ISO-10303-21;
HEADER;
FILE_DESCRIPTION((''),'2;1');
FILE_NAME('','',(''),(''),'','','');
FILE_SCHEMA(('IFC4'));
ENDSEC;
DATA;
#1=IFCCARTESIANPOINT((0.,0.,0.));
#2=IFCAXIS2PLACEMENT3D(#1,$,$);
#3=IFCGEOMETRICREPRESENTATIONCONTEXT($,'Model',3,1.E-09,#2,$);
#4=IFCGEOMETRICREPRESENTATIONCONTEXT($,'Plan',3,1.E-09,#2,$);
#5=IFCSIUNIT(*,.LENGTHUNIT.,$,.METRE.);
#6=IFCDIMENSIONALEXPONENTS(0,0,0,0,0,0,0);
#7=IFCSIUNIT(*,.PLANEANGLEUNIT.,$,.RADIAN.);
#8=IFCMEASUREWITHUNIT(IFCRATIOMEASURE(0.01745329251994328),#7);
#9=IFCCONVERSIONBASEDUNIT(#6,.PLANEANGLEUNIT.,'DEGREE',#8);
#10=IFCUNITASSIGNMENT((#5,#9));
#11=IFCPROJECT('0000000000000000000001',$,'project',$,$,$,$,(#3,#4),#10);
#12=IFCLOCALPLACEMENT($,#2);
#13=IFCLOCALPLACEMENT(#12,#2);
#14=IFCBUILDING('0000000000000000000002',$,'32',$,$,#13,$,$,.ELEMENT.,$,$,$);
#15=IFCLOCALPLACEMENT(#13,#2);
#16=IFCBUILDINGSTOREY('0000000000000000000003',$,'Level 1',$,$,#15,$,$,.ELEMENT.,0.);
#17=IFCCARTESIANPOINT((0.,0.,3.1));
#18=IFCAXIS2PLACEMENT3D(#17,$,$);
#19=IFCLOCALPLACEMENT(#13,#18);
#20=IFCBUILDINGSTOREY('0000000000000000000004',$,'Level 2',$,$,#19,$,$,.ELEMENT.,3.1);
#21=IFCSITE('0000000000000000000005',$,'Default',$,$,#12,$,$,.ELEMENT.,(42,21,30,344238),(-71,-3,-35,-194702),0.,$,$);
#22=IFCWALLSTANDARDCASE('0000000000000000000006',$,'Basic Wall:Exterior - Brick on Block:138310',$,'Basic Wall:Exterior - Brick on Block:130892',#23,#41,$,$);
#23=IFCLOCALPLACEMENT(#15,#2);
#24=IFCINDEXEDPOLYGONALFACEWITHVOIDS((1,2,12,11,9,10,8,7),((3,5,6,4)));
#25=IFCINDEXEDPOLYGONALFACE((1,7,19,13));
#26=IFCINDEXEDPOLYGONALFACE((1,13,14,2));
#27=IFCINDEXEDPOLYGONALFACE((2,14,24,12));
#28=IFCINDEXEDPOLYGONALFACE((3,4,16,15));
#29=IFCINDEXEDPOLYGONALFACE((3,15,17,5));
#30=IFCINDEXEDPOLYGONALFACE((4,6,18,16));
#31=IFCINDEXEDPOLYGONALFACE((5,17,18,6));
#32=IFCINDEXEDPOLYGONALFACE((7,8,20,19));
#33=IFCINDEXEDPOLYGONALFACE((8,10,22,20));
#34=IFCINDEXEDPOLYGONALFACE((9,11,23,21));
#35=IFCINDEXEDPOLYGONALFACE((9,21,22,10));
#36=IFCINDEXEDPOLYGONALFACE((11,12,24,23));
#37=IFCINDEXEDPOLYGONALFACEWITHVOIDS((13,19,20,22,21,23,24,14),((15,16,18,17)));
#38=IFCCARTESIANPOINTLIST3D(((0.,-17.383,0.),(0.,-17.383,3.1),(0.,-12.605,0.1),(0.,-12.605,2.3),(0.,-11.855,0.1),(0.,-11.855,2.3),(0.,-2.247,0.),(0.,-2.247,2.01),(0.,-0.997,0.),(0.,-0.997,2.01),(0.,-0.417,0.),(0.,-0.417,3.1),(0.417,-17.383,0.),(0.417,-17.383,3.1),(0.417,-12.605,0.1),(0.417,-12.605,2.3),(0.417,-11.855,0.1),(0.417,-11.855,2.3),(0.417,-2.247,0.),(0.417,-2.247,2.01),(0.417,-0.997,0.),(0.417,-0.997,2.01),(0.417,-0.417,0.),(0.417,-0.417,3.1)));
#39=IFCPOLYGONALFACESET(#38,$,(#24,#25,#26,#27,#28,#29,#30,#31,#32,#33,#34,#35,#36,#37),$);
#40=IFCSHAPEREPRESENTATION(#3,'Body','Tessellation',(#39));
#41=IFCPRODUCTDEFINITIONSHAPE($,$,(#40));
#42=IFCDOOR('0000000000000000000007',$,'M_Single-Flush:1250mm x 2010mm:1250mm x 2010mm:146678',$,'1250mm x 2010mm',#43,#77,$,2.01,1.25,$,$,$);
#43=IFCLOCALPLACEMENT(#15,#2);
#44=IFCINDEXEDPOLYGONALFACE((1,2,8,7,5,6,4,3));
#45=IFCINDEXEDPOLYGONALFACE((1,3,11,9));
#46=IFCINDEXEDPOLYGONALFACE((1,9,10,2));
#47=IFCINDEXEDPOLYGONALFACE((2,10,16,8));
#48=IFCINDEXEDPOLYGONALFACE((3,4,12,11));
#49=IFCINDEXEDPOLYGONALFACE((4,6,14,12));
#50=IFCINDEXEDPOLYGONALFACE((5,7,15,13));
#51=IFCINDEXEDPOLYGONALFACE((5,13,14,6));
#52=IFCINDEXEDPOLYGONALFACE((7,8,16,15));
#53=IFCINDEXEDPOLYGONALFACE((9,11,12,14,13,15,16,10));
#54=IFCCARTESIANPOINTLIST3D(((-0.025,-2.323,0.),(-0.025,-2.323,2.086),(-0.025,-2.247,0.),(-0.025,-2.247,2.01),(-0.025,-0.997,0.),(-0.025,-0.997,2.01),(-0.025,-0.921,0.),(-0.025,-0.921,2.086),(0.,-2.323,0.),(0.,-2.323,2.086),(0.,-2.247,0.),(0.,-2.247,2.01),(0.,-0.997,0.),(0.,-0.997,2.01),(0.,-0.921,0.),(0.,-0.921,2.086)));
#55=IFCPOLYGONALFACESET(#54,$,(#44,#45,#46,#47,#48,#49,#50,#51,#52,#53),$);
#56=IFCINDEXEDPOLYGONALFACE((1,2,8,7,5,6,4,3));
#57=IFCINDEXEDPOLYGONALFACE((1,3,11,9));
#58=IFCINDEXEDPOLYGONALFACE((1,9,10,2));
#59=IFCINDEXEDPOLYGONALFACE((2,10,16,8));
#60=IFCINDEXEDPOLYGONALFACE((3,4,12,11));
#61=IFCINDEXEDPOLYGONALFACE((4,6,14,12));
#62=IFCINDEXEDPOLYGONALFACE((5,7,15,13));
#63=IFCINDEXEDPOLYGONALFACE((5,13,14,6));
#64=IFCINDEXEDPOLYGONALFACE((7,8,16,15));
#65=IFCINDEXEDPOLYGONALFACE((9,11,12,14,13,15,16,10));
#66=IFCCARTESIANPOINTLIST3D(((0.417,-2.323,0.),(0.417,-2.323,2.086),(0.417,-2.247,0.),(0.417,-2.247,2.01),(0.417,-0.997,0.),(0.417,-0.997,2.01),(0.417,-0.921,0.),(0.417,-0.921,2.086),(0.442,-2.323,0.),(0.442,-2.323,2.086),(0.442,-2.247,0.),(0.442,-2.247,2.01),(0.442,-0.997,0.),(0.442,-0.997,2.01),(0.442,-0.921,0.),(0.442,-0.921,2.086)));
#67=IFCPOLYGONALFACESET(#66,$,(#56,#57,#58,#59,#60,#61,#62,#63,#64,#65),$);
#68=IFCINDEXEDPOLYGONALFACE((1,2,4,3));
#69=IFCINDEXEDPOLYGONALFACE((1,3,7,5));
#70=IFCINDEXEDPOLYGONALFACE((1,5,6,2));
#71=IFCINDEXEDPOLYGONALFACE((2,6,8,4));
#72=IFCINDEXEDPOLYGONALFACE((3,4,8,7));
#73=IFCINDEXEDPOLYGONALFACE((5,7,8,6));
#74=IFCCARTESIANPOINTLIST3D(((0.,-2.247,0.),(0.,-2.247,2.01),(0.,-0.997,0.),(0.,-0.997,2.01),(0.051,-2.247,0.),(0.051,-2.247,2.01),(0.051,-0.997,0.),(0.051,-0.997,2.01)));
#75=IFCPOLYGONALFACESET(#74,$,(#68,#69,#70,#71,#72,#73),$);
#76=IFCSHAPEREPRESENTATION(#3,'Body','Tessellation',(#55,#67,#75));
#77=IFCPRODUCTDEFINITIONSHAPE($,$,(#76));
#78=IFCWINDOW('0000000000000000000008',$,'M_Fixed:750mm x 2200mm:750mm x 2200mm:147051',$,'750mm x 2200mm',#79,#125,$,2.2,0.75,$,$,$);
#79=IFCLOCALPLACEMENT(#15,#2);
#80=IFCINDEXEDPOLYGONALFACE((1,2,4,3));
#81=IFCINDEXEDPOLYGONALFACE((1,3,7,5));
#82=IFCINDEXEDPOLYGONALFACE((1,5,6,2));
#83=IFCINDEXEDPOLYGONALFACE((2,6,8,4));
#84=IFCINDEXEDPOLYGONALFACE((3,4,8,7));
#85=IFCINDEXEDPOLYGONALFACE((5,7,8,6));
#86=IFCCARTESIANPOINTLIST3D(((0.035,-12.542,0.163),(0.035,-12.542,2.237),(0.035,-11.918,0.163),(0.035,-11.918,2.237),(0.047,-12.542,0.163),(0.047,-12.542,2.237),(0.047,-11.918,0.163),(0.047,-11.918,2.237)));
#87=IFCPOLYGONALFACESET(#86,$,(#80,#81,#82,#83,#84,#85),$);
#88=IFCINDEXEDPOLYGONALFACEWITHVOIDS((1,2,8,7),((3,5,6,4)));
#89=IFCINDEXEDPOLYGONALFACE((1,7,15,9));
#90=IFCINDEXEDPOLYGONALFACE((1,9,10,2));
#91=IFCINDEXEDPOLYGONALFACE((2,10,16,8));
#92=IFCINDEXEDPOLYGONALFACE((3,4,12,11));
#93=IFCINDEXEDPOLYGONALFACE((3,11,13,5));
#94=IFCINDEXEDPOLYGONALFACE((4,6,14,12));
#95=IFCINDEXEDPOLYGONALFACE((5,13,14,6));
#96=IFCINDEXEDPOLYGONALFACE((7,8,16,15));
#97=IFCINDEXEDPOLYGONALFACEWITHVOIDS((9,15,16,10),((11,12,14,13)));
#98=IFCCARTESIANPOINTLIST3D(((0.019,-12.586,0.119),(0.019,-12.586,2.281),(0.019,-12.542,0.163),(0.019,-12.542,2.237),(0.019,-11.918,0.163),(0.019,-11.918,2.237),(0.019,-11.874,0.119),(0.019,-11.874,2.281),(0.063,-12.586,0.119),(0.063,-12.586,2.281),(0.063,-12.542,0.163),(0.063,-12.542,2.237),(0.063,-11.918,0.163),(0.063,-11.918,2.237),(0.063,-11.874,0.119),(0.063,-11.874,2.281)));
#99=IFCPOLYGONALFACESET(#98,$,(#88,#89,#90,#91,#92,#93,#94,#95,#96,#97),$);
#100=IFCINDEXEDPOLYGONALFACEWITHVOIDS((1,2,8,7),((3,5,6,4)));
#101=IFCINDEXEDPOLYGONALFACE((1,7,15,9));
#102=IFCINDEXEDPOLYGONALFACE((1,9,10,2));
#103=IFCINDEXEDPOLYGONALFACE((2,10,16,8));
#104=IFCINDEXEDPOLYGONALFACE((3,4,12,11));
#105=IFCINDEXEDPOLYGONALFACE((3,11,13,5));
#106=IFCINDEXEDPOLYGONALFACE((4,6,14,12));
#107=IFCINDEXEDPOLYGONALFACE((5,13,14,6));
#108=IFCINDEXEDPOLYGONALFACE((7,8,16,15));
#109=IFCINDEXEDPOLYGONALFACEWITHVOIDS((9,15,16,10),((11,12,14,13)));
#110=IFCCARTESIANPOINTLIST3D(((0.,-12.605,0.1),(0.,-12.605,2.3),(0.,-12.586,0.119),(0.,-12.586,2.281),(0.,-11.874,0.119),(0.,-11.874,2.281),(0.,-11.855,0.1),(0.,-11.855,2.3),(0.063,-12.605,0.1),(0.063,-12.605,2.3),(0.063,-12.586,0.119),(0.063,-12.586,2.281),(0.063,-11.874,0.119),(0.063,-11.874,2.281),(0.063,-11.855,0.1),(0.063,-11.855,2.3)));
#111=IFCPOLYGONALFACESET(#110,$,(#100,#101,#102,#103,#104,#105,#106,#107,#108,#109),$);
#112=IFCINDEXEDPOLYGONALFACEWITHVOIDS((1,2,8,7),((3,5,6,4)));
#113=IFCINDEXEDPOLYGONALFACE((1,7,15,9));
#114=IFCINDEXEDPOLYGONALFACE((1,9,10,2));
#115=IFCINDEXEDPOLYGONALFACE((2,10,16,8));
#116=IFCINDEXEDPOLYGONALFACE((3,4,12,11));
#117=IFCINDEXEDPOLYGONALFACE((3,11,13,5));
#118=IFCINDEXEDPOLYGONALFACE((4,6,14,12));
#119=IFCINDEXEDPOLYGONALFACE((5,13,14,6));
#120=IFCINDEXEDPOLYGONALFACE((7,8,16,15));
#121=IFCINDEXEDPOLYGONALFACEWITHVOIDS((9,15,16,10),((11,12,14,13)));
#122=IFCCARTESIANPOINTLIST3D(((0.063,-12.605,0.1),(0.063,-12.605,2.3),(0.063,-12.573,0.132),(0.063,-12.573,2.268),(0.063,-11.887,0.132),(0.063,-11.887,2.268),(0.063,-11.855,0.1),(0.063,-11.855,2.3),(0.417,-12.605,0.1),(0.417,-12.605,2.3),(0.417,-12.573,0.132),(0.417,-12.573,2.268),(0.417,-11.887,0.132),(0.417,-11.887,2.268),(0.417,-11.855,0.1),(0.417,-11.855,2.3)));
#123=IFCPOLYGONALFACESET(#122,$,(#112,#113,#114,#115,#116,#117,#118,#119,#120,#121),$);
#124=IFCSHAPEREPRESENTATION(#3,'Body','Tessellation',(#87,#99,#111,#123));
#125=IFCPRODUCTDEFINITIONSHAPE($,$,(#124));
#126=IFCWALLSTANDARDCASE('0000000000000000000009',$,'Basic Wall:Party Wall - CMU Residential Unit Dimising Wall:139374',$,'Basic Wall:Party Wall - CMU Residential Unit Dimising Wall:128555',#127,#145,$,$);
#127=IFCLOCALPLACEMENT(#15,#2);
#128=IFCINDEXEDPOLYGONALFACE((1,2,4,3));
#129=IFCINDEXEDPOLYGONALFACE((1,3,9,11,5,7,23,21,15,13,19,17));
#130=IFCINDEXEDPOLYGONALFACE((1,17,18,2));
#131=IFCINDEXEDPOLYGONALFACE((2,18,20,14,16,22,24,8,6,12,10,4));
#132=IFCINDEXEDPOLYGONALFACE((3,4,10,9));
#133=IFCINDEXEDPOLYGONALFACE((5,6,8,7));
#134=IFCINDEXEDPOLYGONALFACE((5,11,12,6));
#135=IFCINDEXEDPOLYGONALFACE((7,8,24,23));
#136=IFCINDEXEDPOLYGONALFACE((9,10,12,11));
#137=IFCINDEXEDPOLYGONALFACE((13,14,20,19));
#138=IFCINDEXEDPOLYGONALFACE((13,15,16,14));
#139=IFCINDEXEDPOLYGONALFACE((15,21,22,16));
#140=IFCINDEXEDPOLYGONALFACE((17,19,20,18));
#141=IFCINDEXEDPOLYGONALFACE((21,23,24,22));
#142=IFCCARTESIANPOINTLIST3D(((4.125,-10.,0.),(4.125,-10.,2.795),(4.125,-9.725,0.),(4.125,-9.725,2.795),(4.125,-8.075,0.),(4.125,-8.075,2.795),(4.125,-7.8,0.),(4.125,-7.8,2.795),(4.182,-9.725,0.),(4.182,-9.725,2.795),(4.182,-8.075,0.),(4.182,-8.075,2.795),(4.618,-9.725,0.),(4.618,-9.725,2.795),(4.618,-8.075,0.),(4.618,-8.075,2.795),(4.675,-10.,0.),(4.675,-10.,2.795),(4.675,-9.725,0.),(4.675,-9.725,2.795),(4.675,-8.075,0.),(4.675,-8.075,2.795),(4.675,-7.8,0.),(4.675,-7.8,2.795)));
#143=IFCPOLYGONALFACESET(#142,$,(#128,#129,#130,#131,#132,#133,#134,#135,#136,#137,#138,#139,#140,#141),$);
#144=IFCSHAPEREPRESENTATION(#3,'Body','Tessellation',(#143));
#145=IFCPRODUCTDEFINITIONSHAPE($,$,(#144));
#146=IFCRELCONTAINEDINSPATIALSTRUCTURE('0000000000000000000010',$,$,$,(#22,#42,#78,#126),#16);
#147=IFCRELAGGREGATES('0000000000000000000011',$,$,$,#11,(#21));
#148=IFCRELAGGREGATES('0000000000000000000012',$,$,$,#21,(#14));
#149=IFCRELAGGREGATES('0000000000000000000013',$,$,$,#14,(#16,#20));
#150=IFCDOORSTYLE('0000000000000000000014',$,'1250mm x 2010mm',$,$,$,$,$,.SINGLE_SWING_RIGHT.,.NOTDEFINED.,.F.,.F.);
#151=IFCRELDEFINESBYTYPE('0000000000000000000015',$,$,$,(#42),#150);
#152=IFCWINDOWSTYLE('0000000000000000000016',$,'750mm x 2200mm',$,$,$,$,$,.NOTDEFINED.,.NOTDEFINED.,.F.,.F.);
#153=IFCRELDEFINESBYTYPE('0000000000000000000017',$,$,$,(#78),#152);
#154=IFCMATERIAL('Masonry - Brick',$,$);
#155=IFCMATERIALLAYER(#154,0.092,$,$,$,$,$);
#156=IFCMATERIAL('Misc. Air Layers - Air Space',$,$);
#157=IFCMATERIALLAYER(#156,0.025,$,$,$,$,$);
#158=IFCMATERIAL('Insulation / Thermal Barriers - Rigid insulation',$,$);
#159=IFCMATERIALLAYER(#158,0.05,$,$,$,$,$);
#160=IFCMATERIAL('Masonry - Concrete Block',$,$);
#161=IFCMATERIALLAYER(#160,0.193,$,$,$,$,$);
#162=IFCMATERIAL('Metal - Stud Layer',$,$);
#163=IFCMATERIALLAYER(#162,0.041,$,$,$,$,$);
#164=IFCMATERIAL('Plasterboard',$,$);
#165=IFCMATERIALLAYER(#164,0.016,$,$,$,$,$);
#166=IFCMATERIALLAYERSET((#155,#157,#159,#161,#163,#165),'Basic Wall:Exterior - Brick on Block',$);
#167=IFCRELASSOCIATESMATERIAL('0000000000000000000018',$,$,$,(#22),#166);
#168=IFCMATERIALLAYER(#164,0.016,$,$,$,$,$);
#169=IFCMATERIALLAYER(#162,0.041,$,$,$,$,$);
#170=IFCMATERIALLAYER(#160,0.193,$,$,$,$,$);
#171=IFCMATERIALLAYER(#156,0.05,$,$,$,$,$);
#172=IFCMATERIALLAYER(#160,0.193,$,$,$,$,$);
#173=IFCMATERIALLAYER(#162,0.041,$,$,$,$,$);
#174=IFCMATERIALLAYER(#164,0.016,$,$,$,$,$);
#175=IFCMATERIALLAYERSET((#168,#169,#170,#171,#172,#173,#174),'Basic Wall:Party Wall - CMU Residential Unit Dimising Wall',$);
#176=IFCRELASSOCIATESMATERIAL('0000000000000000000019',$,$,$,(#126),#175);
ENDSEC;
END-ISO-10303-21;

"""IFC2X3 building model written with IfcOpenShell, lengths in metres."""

from ifc_helpers import new_model, entity, si_unit, converted_unit, frame, frame_2d, origin, origin_2d_with_axis, place, context, project, spatial, polyline, rectangle, outline, extrude, clip, bounded_halfspace, source, transform, mapped, material, layer, layer_set, layer_usage, type_object, type_shapes, element, fill, save


model = new_model("IFC2X3")

# Units and contexts
model_context = context("Model", 3, precision=1e-09, world=origin())
plan_context = context("Plan", 3, precision=1e-09, world=origin())
ifc_project = project(units=[si_unit("LENGTHUNIT", "METRE"), converted_unit("PLANEANGLEUNIT", "DEGREE", entity("IfcRatioMeasure", 0.01745329251994328), si_unit("PLANEANGLEUNIT", "RADIAN"), dimensions=[0, 0, 0, 0, 0, 0, 0])], contexts=[model_context, plan_context])

# Site, building, storey
site_placement = place(None, origin())
site = spatial("IfcSite", under=ifc_project, at=site_placement, Name="Default", CompositionType="ELEMENT", RefLatitude=(42, 21, 30, 344238), RefLongitude=(-71, -3, -35, -194702), RefElevation=0.0)
building_placement = place(site_placement, origin())
building = spatial("IfcBuilding", under=site, at=building_placement, Name="32", CompositionType="ELEMENT")
storey_1_placement = place(building_placement, origin())
storey_1 = spatial("IfcBuildingStorey", under=building, at=storey_1_placement, Name="Level 1", CompositionType="ELEMENT", Elevation=0.0)

# Shared definitions
ifc_material_1 = material(Name="Masonry - Brick")
ifc_layer_1 = layer(ifc_material_1, 0.092)
ifc_material_2 = material(Name="Misc. Air Layers - Air Space")
ifc_layer_2 = layer(ifc_material_2, 0.025)
ifc_material_3 = material(Name="Insulation / Thermal Barriers - Rigid insulation")
ifc_layer_3 = layer(ifc_material_3, 0.05)
ifc_material_4 = material(Name="Masonry - Concrete Block")
ifc_layer_4 = layer(ifc_material_4, 0.193)
ifc_material_5 = material(Name="Metal - Stud Layer")
ifc_layer_5 = layer(ifc_material_5, 0.041)
ifc_material_6 = material(Name="Plasterboard")
ifc_layer_6 = layer(ifc_material_6, 0.016)
ifc_layer_set_1 = layer_set([ifc_layer_1, ifc_layer_2, ifc_layer_3, ifc_layer_4, ifc_layer_5, ifc_layer_6], Name="Basic Wall:Exterior - Brick on Block")

# Wall, openings, door, window
ifc_layer_usage_1 = layer_usage(ifc_layer_set_1, "AXIS2", "NEGATIVE", 0.2085)
wall_1_placement = place(storey_1_placement, frame((0.2085, -17.383, 0.0), z_axis=(0.0, 0.0, 1.0), x_axis=(0.0, 1.0, 0.0)))
wall_1 = element("IfcWallStandardCase", 1, at=wall_1_placement, inside=storey_1, material=ifc_layer_usage_1, Name="Basic Wall:Exterior - Brick on Block:138310", ObjectType="Basic Wall:Exterior - Brick on Block:130892", context=model_context, shape_type="SweptSolid", body=[
    extrude(rectangle(XDim=16.966, YDim=0.417, at=frame_2d((8.483, 0.0), x_axis=(-1.0, 0.0))), origin(), (0.0, 0.0, 1.0), 3.1),
])
opening_1_placement = place(wall_1_placement, frame((15.136, -0.2085, 0.0)))
opening_1 = element("IfcOpeningElement", 2, at=opening_1_placement, cuts=wall_1, ObjectType="Opening", context=model_context, shape_type="SweptSolid", body=[
    extrude(rectangle(XDim=1.25, YDim=2.01, at=frame_2d((1.005, 0.625), x_axis=(0.0, 1.0))), frame((0.0, 0.0, 0.0), z_axis=(0.0, 1.0, 0.0), x_axis=(0.0, 0.0, 1.0)), (0.0, 0.0, 1.0), 0.417),
])
opening_2_placement = place(wall_1_placement, frame((4.778, -0.2085, 0.1)))
opening_2 = element("IfcOpeningElement", 3, at=opening_2_placement, cuts=wall_1, ObjectType="Opening", context=model_context, shape_type="SweptSolid", body=[
    extrude(rectangle(XDim=2.2, YDim=0.75, at=frame_2d((1.1, 0.375), x_axis=(1.0, 0.0))), frame((0.0, 0.0, 0.0), z_axis=(0.0, 1.0, 0.0), x_axis=(0.0, 0.0, 1.0)), (0.0, 0.0, 1.0), 0.417),
])
door_style_1 = type_object("IfcDoorStyle", Name="1250mm x 2010mm", ConstructionType="NOTDEFINED", OperationType="SINGLE_SWING_RIGHT", ParameterTakesPrecedence=False, Sizeable=False)
shared_shape_1 = source(origin(), model_context, "Body", "SweptSolid", [
    extrude(outline(polyline([(-0.701, -1.062), (0.701, -1.062), (0.701, 1.024), (0.625, 1.024), (0.625, -0.986), (-0.625, -0.986), (-0.625, 1.024), (-0.701, 1.024), (-0.701, -1.062)])), frame((0.625, 0.417, 1.024), z_axis=(0.0, 1.0, 0.0), x_axis=(1.0, 0.0, 0.0)), (0.0, 0.0, 1.0), 0.025),
    extrude(outline(polyline([(-1.062, -0.701), (1.024, -0.701), (1.024, -0.625), (-0.986, -0.625), (-0.986, 0.625), (1.024, 0.625), (1.024, 0.701), (-1.062, 0.701), (-1.062, -0.701)])), frame((0.625, -0.025, 1.024), z_axis=(0.0, 1.0, 0.0), x_axis=(0.0, 0.0, -1.0)), (0.0, 0.0, 1.0), 0.025),
    extrude(rectangle(XDim=0.051, YDim=1.25, at=origin_2d_with_axis()), frame((0.625, 0.3915, 0.0), z_axis=(0.0, 0.0, 1.0), x_axis=(0.0, 1.0, 0.0)), (0.0, 0.0, 1.0), 2.01),
])
type_shapes(door_style_1, [shared_shape_1])
door_1_placement = place(opening_1_placement, origin())
door_1 = element("IfcDoor", 4, at=door_1_placement, inside=storey_1, type_object=door_style_1, Name="M_Single-Flush:1250mm x 2010mm:1250mm x 2010mm:146678", ObjectType="1250mm x 2010mm", OverallHeight=2.01, OverallWidth=1.25, context=model_context, shape_type="MappedRepresentation", body=[
    mapped(shared_shape_1, transform((0.0, 0.0, 0.0), scale=1.0)),
])
fill(opening_1, door_1)
window_style_1 = type_object("IfcWindowStyle", Name="750mm x 2200mm", ConstructionType="NOTDEFINED", OperationType="NOTDEFINED", ParameterTakesPrecedence=False, Sizeable=False)
shared_shape_2 = source(origin(), model_context, "Body", "SweptSolid", [
    extrude(rectangle(XDim=0.012, YDim=0.624, at=origin_2d_with_axis()), frame((0.375, 0.376, 0.063), z_axis=(0.0, 0.0, 1.0), x_axis=(0.0, -1.0, 0.0)), (0.0, 0.0, 1.0), 2.074),
    extrude(outline(polyline([(-0.356, -1.081), (0.356, -1.081), (0.356, 1.081), (-0.356, 1.081), (-0.356, -1.081)]), holes=[polyline([(-0.312, -1.037), (-0.312, 1.037), (0.312, 1.037), (0.312, -1.037), (-0.312, -1.037)])]), frame((0.375, 0.354, 1.1), z_axis=(0.0, 1.0, 0.0), x_axis=(1.0, 0.0, 0.0)), (0.0, 0.0, 1.0), 0.044),
    extrude(outline(polyline([(-0.375, -1.1), (0.375, -1.1), (0.375, 1.1), (-0.375, 1.1), (-0.375, -1.1)]), holes=[polyline([(-0.356, -1.081), (-0.356, 1.081), (0.356, 1.081), (0.356, -1.081), (-0.356, -1.081)])]), frame((0.375, 0.354, 1.1), z_axis=(0.0, 1.0, 0.0), x_axis=(1.0, 0.0, 0.0)), (0.0, 0.0, 1.0), 0.063),
    extrude(outline(polyline([(-0.375, -1.1), (0.375, -1.1), (0.375, 1.1), (-0.375, 1.1), (-0.375, -1.1)]), holes=[polyline([(-0.343, -1.068), (-0.343, 1.068), (0.343, 1.068), (0.343, -1.068), (-0.343, -1.068)])]), frame((0.375, 0.0, 1.1), z_axis=(0.0, 1.0, 0.0), x_axis=(1.0, 0.0, 0.0)), (0.0, 0.0, 1.0), 0.354),
])
type_shapes(window_style_1, [shared_shape_2])
window_1_placement = place(opening_2_placement, origin())
window_1 = element("IfcWindow", 5, at=window_1_placement, inside=storey_1, type_object=window_style_1, Name="M_Fixed:750mm x 2200mm:750mm x 2200mm:147051", ObjectType="750mm x 2200mm", OverallHeight=2.2, OverallWidth=0.75, context=model_context, shape_type="MappedRepresentation", body=[
    mapped(shared_shape_2, transform((0.0, 0.0, 0.0), scale=1.0)),
])
fill(opening_2, window_1)

# Wall
ifc_layer_7 = layer(ifc_material_6, 0.016)
ifc_layer_8 = layer(ifc_material_5, 0.041)
ifc_layer_9 = layer(ifc_material_4, 0.193)
ifc_layer_10 = layer(ifc_material_2, 0.05)
ifc_layer_11 = layer(ifc_material_4, 0.193)
ifc_layer_12 = layer(ifc_material_5, 0.041)
ifc_layer_13 = layer(ifc_material_6, 0.016)
ifc_layer_set_2 = layer_set([ifc_layer_7, ifc_layer_8, ifc_layer_9, ifc_layer_10, ifc_layer_11, ifc_layer_12, ifc_layer_13], Name="Basic Wall:Party Wall - CMU Residential Unit Dimising Wall")
ifc_layer_usage_2 = layer_usage(ifc_layer_set_2, "AXIS2", "NEGATIVE", 0.275)
wall_2_placement = place(storey_1_placement, frame((4.4, -10.0, 0.0), z_axis=(0.0, 0.0, 1.0), x_axis=(0.0, 1.0, 0.0)))
element("IfcWallStandardCase", 6, at=wall_2_placement, inside=storey_1, material=ifc_layer_usage_2, Name="Basic Wall:Party Wall - CMU Residential Unit Dimising Wall:139374", ObjectType="Basic Wall:Party Wall - CMU Residential Unit Dimising Wall:128555", context=model_context, shape_type="Clipping", body=[
    clip(clip(extrude(rectangle(XDim=2.2, YDim=0.55, at=frame_2d((1.1, 0.0), x_axis=(-1.0, 0.0))), origin(), (0.0, 0.0, 1.0), 2.795), bounded_halfspace(frame((1.925, 0.218, 0.0), z_axis=(0.0, -1.0, 0.0), x_axis=(1.0, 0.0, 0.0)), True, frame((1.925, 0.218, 0.0), z_axis=(0.0, -1.0, 0.0), x_axis=(1.0, 0.0, 0.0)), polyline([(0.0, 0.0), (0.0, 2.795), (-1.65, 2.795), (-1.65, 0.0), (0.0, 0.0)]))), bounded_halfspace(frame((0.275, -0.218, 0.0), z_axis=(0.0, 1.0, 0.0), x_axis=(-1.0, 0.0, 0.0)), True, frame((0.275, -0.218, 0.0), z_axis=(0.0, 1.0, 0.0), x_axis=(-1.0, 0.0, 0.0)), polyline([(0.0, 0.0), (0.0, 2.795), (-1.65, 2.795), (-1.65, 0.0), (0.0, 0.0)]))),
])

# Shared definitions
storey_2_placement = place(building_placement, frame((0.0, 0.0, 3.1)))
storey_2 = spatial("IfcBuildingStorey", under=building, at=storey_2_placement, Name="Level 2", CompositionType="ELEMENT", Elevation=3.1)

save(model, "model.ifc")
